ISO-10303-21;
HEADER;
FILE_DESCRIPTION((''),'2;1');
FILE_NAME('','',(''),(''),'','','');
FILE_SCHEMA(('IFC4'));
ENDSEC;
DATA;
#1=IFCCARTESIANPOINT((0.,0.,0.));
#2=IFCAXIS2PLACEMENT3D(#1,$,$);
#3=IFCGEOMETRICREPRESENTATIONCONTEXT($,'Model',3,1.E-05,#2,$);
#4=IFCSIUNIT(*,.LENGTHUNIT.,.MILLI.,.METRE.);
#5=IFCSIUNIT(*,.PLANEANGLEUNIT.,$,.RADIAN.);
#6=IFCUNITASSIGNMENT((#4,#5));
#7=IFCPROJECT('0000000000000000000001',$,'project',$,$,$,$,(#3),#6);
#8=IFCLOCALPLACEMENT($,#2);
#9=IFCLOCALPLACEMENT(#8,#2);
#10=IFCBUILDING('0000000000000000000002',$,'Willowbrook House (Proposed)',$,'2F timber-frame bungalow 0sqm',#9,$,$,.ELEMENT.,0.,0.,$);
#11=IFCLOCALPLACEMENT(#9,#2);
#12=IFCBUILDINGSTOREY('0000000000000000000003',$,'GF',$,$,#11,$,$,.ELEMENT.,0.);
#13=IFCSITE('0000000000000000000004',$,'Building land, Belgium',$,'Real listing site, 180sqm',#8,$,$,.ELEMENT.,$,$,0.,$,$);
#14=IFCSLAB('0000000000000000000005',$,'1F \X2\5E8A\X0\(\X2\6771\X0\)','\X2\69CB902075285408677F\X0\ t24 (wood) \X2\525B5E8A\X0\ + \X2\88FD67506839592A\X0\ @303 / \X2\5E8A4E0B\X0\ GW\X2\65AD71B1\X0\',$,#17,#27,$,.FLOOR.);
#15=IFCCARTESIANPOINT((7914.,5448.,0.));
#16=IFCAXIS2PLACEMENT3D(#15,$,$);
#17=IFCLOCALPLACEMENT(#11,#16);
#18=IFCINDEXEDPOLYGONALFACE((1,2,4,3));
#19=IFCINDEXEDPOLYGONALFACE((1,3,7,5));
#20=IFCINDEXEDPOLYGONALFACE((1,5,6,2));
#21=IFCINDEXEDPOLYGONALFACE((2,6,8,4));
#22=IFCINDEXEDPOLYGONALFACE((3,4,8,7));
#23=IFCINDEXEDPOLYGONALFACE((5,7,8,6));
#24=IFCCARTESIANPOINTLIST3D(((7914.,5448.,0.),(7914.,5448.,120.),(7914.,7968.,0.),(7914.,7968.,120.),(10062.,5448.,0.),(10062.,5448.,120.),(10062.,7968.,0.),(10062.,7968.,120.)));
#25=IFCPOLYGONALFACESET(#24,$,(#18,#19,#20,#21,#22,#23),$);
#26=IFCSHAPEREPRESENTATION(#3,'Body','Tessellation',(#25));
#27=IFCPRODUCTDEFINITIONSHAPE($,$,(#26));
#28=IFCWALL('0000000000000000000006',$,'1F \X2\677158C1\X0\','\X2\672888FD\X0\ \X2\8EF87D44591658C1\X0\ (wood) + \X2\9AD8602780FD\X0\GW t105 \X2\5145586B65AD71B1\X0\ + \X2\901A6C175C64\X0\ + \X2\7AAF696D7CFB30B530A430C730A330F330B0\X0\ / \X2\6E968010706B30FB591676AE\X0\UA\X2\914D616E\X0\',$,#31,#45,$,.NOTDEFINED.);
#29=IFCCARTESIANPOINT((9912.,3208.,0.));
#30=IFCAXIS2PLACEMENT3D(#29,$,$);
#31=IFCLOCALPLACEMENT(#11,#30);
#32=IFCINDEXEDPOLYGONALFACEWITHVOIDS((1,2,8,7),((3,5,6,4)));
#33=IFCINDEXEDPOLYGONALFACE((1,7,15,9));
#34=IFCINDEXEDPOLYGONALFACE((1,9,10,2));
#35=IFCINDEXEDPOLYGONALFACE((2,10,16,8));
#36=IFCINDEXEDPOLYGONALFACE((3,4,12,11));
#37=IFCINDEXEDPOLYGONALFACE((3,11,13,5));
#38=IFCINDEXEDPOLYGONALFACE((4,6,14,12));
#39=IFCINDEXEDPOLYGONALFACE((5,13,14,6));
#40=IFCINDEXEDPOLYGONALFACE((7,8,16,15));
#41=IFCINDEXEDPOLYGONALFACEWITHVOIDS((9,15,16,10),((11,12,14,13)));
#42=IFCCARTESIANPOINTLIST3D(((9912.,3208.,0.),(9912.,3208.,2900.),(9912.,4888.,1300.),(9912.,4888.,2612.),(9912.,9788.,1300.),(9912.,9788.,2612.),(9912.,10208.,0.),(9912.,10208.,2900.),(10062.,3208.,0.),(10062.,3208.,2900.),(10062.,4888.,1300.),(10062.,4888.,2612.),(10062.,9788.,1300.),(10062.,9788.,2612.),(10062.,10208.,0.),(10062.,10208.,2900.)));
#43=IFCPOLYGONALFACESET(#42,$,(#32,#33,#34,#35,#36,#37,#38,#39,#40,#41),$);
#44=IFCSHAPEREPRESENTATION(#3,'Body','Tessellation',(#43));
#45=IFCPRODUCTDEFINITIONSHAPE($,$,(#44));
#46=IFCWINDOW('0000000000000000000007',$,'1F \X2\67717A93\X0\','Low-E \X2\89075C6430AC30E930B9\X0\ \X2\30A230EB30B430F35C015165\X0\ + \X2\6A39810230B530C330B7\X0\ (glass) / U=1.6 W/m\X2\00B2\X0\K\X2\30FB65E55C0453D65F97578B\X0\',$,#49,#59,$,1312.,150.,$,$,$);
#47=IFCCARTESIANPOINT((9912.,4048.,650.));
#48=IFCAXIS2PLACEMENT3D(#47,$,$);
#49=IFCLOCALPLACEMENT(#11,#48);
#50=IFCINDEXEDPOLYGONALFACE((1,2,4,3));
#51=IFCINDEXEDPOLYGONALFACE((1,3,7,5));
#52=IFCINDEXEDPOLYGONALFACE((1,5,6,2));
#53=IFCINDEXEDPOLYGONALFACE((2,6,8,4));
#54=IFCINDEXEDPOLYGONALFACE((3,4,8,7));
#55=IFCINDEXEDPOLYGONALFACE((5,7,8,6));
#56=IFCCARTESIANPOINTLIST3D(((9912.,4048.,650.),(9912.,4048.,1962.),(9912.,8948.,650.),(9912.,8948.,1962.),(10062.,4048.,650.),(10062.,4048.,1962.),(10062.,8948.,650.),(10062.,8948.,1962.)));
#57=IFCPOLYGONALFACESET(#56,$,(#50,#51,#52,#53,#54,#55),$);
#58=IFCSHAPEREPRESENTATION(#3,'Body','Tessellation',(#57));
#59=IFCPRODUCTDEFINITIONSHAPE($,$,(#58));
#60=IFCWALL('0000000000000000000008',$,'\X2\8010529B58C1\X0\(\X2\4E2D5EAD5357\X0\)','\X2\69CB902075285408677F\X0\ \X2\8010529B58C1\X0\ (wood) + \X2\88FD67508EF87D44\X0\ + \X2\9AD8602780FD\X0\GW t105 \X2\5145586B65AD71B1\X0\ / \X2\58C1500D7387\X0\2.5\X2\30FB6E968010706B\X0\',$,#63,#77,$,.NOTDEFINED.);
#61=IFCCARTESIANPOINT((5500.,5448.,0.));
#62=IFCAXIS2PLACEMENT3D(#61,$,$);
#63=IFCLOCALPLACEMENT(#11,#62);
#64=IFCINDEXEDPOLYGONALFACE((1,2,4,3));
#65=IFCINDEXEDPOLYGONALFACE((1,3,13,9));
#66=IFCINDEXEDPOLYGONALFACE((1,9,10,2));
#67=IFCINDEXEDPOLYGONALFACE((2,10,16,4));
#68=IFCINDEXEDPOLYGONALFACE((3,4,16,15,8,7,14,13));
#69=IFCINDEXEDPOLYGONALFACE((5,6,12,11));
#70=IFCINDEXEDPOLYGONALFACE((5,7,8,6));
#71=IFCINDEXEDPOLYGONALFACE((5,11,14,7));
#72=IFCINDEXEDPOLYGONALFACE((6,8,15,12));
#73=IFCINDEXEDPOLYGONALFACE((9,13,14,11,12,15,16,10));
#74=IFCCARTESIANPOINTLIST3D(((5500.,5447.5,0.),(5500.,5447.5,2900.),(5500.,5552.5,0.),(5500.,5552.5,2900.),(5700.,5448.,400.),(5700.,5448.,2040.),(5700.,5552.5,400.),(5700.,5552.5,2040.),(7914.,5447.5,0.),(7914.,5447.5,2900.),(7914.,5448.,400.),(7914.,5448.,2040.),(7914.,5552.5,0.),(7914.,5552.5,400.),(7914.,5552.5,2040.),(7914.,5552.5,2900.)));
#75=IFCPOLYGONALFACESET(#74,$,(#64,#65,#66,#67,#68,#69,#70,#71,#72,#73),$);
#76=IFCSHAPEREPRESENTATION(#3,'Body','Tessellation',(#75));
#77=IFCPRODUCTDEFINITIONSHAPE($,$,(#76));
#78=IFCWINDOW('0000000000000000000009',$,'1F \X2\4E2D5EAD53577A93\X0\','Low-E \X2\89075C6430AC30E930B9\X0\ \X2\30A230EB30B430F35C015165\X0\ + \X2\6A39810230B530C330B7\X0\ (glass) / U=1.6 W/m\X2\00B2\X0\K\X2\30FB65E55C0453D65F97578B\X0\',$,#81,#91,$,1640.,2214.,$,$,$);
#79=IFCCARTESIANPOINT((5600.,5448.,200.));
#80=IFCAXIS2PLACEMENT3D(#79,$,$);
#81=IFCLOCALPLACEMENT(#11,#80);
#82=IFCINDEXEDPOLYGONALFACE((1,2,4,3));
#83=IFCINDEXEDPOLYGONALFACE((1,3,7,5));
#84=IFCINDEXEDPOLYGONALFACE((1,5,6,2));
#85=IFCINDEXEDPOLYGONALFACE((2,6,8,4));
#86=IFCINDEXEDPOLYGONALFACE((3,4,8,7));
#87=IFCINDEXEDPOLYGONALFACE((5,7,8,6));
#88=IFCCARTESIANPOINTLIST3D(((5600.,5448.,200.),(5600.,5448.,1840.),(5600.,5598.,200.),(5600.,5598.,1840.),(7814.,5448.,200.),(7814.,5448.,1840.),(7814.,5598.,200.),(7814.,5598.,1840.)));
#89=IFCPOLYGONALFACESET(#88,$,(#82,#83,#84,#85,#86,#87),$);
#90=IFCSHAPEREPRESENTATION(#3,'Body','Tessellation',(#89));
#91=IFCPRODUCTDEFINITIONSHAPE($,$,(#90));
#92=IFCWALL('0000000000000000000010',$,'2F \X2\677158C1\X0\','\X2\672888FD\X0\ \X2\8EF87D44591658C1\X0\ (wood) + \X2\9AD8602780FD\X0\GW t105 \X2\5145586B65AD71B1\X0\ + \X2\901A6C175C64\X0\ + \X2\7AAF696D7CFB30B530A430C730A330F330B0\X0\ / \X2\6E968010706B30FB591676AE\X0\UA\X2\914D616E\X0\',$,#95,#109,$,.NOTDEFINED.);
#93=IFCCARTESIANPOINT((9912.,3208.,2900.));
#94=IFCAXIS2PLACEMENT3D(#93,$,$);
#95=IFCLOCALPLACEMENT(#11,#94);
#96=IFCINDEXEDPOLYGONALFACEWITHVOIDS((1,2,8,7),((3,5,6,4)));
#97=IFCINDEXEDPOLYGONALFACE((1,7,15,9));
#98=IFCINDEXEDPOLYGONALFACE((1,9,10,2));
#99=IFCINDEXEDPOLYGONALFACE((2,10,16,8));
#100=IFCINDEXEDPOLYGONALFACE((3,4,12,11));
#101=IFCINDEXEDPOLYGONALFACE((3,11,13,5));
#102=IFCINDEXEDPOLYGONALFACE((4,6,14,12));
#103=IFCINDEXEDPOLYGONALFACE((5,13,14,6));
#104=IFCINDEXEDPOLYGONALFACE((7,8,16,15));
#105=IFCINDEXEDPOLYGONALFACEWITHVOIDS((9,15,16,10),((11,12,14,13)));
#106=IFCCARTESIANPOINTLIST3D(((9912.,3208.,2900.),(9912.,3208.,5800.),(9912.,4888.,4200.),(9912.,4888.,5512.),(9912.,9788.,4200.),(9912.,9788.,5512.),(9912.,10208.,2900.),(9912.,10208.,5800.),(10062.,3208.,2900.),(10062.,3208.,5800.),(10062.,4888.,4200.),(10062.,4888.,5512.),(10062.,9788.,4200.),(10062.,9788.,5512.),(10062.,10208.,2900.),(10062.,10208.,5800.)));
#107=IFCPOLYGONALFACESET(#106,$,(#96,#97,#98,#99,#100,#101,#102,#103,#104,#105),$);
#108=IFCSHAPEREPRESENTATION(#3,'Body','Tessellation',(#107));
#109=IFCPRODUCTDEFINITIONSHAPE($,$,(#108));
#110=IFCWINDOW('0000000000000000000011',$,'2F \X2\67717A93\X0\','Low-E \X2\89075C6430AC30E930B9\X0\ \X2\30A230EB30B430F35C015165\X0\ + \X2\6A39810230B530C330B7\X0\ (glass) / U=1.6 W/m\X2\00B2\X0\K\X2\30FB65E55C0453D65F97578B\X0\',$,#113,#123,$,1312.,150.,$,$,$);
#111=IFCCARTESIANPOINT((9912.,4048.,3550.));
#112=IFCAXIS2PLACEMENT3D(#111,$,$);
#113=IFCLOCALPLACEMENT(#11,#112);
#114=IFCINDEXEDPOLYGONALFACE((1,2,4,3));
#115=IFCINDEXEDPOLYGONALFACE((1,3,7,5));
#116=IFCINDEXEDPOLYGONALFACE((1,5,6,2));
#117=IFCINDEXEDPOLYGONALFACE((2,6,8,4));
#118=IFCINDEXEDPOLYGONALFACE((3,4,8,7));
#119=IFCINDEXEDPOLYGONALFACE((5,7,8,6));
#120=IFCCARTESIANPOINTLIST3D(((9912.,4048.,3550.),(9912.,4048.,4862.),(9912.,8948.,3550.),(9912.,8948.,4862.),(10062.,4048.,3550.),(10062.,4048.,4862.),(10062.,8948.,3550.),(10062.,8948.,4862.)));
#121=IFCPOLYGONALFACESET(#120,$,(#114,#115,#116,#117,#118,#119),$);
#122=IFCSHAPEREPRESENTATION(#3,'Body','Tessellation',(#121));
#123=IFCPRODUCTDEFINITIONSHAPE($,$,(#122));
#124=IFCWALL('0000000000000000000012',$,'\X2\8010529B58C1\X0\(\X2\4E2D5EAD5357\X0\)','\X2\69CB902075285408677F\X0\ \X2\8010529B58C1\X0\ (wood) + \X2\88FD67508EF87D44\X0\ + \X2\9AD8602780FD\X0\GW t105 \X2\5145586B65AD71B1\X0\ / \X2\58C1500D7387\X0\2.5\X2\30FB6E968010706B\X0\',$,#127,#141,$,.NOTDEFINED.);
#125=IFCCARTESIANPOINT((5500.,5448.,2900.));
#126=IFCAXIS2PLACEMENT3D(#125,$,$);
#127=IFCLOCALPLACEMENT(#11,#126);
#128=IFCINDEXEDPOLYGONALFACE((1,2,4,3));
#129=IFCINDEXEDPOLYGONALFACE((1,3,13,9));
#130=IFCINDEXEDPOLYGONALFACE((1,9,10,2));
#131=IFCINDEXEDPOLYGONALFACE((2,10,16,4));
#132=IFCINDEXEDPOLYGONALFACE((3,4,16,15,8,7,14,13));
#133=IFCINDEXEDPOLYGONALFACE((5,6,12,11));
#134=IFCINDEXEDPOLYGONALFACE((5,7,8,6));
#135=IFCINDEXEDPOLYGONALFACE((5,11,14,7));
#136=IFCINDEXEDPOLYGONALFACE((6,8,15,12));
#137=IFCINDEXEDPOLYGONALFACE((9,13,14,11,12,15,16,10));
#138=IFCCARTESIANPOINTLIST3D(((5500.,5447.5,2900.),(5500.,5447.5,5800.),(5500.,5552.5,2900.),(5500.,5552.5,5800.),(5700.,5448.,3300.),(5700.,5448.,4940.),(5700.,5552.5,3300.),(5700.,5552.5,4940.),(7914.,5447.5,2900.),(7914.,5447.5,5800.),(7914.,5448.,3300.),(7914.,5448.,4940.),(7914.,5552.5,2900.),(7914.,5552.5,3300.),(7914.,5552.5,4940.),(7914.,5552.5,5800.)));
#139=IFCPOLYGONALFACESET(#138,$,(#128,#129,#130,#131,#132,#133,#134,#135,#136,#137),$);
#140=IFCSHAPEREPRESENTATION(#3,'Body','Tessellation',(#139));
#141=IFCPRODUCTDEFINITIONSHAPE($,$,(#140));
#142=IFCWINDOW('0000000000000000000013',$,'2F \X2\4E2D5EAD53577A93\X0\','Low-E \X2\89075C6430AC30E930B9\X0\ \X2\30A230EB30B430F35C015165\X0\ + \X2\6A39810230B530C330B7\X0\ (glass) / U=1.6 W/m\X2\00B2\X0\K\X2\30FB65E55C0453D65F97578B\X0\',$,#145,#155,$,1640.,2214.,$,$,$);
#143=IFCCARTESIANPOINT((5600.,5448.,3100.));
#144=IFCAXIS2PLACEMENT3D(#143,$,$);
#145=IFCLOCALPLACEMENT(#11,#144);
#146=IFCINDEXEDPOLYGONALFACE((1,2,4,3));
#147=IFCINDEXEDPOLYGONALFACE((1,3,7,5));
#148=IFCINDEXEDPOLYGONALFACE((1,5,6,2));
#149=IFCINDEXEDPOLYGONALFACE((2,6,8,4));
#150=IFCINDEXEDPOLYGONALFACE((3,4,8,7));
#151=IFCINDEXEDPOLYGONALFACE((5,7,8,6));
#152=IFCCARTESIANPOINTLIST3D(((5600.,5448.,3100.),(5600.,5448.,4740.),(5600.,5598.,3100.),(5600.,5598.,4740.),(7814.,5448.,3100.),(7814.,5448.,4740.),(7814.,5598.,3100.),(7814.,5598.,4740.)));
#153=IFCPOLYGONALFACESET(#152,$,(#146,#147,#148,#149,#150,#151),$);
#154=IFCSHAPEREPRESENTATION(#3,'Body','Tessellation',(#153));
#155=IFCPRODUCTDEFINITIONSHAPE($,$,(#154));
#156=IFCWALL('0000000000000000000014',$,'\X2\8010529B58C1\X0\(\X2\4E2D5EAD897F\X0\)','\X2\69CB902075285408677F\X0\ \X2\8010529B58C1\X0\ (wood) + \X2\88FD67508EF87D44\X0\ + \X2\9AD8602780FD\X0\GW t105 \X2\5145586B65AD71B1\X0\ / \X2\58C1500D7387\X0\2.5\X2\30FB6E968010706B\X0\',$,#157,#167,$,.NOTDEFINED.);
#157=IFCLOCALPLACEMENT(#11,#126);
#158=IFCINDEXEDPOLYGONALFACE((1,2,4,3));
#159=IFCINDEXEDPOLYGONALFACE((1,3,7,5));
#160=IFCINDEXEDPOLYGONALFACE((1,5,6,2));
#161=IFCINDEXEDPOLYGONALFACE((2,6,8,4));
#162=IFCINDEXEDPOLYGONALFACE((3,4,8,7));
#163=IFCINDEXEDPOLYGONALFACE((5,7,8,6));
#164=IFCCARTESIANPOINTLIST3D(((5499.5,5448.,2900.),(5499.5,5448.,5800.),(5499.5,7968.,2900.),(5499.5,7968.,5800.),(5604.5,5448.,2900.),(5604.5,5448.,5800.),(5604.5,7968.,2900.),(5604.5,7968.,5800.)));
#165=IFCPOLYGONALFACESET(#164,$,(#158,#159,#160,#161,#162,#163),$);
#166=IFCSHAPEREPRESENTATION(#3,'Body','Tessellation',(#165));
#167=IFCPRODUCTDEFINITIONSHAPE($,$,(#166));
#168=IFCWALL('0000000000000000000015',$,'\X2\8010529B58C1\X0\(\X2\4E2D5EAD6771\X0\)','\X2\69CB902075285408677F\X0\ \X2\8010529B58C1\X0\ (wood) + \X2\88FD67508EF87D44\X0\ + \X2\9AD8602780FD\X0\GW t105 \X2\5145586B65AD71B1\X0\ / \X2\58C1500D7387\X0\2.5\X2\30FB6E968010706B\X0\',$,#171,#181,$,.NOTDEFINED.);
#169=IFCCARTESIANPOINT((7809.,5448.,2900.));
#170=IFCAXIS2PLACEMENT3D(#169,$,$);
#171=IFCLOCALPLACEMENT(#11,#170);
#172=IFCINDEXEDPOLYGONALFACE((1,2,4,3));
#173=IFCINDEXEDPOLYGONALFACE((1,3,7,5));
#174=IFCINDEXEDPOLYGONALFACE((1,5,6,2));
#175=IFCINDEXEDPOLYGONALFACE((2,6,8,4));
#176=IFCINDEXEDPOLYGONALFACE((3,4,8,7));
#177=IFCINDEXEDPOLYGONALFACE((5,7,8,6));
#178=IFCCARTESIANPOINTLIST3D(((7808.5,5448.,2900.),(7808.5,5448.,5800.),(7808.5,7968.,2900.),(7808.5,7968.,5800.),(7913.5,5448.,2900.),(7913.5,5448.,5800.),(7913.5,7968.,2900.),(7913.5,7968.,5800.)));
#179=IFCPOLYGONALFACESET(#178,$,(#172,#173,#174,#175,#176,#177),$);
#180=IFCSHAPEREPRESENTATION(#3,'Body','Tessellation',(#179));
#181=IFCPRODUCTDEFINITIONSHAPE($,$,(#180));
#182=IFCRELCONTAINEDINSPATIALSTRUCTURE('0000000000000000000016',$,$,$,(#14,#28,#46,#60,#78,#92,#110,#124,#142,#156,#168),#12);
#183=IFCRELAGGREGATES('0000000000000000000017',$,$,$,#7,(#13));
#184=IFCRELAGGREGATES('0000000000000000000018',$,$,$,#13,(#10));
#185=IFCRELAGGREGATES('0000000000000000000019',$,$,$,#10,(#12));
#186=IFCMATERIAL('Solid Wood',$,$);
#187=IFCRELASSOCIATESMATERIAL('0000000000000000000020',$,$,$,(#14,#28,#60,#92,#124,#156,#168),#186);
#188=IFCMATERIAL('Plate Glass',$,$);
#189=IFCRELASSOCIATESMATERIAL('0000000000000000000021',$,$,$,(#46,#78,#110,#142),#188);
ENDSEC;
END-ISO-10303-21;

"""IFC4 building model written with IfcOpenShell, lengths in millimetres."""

from ifc_helpers import new_model, si_unit, frame, frame_2d, origin, place, context, project, spatial, rectangle, extrude, material, element, fill, save


model = new_model("IFC4")

# Units and contexts
model_context = context("Model", 3, precision=1e-05, world=origin())
ifc_project = project(units=[si_unit("LENGTHUNIT", "METRE", prefix="MILLI"), si_unit("PLANEANGLEUNIT", "RADIAN")], contexts=[model_context])

# Site, building, storey
site_placement = place(None, origin())
site = spatial("IfcSite", under=ifc_project, at=site_placement, Name="Building land, Belgium", ObjectType="Real listing site, 180sqm", CompositionType="ELEMENT", RefElevation=0.0)
building_placement = place(site_placement, origin())
building = spatial("IfcBuilding", under=site, at=building_placement, Name="Willowbrook House (Proposed)", ObjectType="2F timber-frame bungalow 0sqm", CompositionType="ELEMENT", ElevationOfRefHeight=0.0, ElevationOfTerrain=0.0)
storey_placement = place(building_placement, origin())
storey = spatial("IfcBuildingStorey", under=building, at=storey_placement, Name="GF", CompositionType="ELEMENT", Elevation=0.0)

# Slab
ifc_material_1 = material(Name="Solid Wood")
slab_placement = place(storey_placement, frame((7914.0, 5448.0, 0.0)))
element("IfcSlab", 1, at=slab_placement, inside=storey, material=ifc_material_1, Name="1F 床(東)", Description="構造用合板 t24 (wood) 剛床 + 製材根太 @303 / 床下 GW断熱", PredefinedType="FLOOR", context=model_context, shape_type="SweptSolid", body=[
    extrude(rectangle(XDim=2148.0, YDim=2520.0, at=frame_2d((1074.0, 1260.0))), frame((7914.0, 5448.0, 0.0)), (0.0, 0.0, 1.0), 120.0),
])

# Walls, openings, windows
wall_1_placement = place(storey_placement, frame((9912.0, 3208.0, 0.0)))
wall_1 = element("IfcWall", 2, at=wall_1_placement, inside=storey, material=ifc_material_1, Name="1F 東壁", Description="木製 軸組外壁 (wood) + 高性能GW t105 充填断熱 + 通気層 + 窯業系サイディング / 準耐火・外皮UA配慮", PredefinedType="NOTDEFINED", context=model_context, shape_type="SweptSolid", body=[
    extrude(rectangle(XDim=150.0, YDim=7000.0, at=frame_2d((75.0, 3500.0))), frame((9912.0, 3208.0, 0.0)), (0.0, 0.0, 1.0), 2900.0),
])
opening_1_placement = place(storey_placement, frame((9912.0, 4048.0, 650.0)))
opening_1 = element("IfcOpeningElement", 3, at=opening_1_placement, cuts=wall_1, PredefinedType="NOTDEFINED", context=model_context, shape_type="SweptSolid", body=[
    extrude(rectangle(XDim=150.0, YDim=4900.0, at=frame_2d((75.0, 2450.0))), frame((9912.0, 4048.0, 650.0)), (0.0, 0.0, 1.0), 1312.0),
])
ifc_material_2 = material(Name="Plate Glass")
window_1_placement = place(storey_placement, frame((9912.0, 4048.0, 650.0)))
window_1 = element("IfcWindow", 4, at=window_1_placement, inside=storey, material=ifc_material_2, Name="1F 東窓", Description="Low-E 複層ガラス アルゴン封入 + 樹脂サッシ (glass) / U=1.6 W/m²K・日射取得型", OverallHeight=1312.0, OverallWidth=150.0, context=model_context, shape_type="SweptSolid", body=[
    extrude(rectangle(XDim=150.0, YDim=4900.0, at=frame_2d((75.0, 2450.0))), frame((9912.0, 4048.0, 650.0)), (0.0, 0.0, 1.0), 1312.0),
])
fill(opening_1, window_1)
wall_2_placement = place(storey_placement, frame((5500.0, 5448.0, 0.0)))
wall_2 = element("IfcWall", 5, at=wall_2_placement, inside=storey, material=ifc_material_1, Name="耐力壁(中庭南)", Description="構造用合板 耐力壁 (wood) + 製材軸組 + 高性能GW t105 充填断熱 / 壁倍率2.5・準耐火", PredefinedType="NOTDEFINED", context=model_context, shape_type="SweptSolid", body=[
    extrude(rectangle(XDim=2414.0, YDim=105.0, at=frame_2d((1207.0, 52.0))), frame((5500.0, 5448.0, 0.0)), (0.0, 0.0, 1.0), 2900.0),
])
opening_2_placement = place(storey_placement, frame((5600.0, 5448.0, 200.0)))
opening_2 = element("IfcOpeningElement", 6, at=opening_2_placement, cuts=wall_2, PredefinedType="NOTDEFINED", context=model_context, shape_type="SweptSolid", body=[
    extrude(rectangle(XDim=2214.0, YDim=150.0, at=frame_2d((1107.0, 75.0))), frame((5600.0, 5448.0, 200.0)), (0.0, 0.0, 1.0), 1640.0),
])
window_2_placement = place(storey_placement, frame((5600.0, 5448.0, 200.0)))
window_2 = element("IfcWindow", 7, at=window_2_placement, inside=storey, material=ifc_material_2, Name="1F 中庭南窓", Description="Low-E 複層ガラス アルゴン封入 + 樹脂サッシ (glass) / U=1.6 W/m²K・日射取得型", OverallHeight=1640.0, OverallWidth=2214.0, context=model_context, shape_type="SweptSolid", body=[
    extrude(rectangle(XDim=2214.0, YDim=150.0, at=frame_2d((1107.0, 75.0))), frame((5600.0, 5448.0, 200.0)), (0.0, 0.0, 1.0), 1640.0),
])
fill(opening_2, window_2)

# Walls, openings, windows
wall_3_placement = place(storey_placement, frame((9912.0, 3208.0, 2900.0)))
wall_3 = element("IfcWall", 8, at=wall_3_placement, inside=storey, material=ifc_material_1, Name="2F 東壁", Description="木製 軸組外壁 (wood) + 高性能GW t105 充填断熱 + 通気層 + 窯業系サイディング / 準耐火・外皮UA配慮", PredefinedType="NOTDEFINED", context=model_context, shape_type="SweptSolid", body=[
    extrude(rectangle(XDim=150.0, YDim=7000.0, at=frame_2d((75.0, 3500.0))), frame((9912.0, 3208.0, 2900.0)), (0.0, 0.0, 1.0), 2900.0),
])
opening_3_placement = place(storey_placement, frame((9912.0, 4048.0, 3550.0)))
opening_3 = element("IfcOpeningElement", 9, at=opening_3_placement, cuts=wall_3, PredefinedType="NOTDEFINED", context=model_context, shape_type="SweptSolid", body=[
    extrude(rectangle(XDim=150.0, YDim=4900.0, at=frame_2d((75.0, 2450.0))), frame((9912.0, 4048.0, 3550.0)), (0.0, 0.0, 1.0), 1312.0),
])
window_3_placement = place(storey_placement, frame((9912.0, 4048.0, 3550.0)))
window_3 = element("IfcWindow", 10, at=window_3_placement, inside=storey, material=ifc_material_2, Name="2F 東窓", Description="Low-E 複層ガラス アルゴン封入 + 樹脂サッシ (glass) / U=1.6 W/m²K・日射取得型", OverallHeight=1312.0, OverallWidth=150.0, context=model_context, shape_type="SweptSolid", body=[
    extrude(rectangle(XDim=150.0, YDim=4900.0, at=frame_2d((75.0, 2450.0))), frame((9912.0, 4048.0, 3550.0)), (0.0, 0.0, 1.0), 1312.0),
])
fill(opening_3, window_3)
wall_4_placement = place(storey_placement, frame((5500.0, 5448.0, 2900.0)))
wall_4 = element("IfcWall", 11, at=wall_4_placement, inside=storey, material=ifc_material_1, Name="耐力壁(中庭南)", Description="構造用合板 耐力壁 (wood) + 製材軸組 + 高性能GW t105 充填断熱 / 壁倍率2.5・準耐火", PredefinedType="NOTDEFINED", context=model_context, shape_type="SweptSolid", body=[
    extrude(rectangle(XDim=2414.0, YDim=105.0, at=frame_2d((1207.0, 52.0))), frame((5500.0, 5448.0, 2900.0)), (0.0, 0.0, 1.0), 2900.0),
])
opening_4_placement = place(storey_placement, frame((5600.0, 5448.0, 3100.0)))
opening_4 = element("IfcOpeningElement", 12, at=opening_4_placement, cuts=wall_4, PredefinedType="NOTDEFINED", context=model_context, shape_type="SweptSolid", body=[
    extrude(rectangle(XDim=2214.0, YDim=150.0, at=frame_2d((1107.0, 75.0))), frame((5600.0, 5448.0, 3100.0)), (0.0, 0.0, 1.0), 1640.0),
])
window_4_placement = place(storey_placement, frame((5600.0, 5448.0, 3100.0)))
window_4 = element("IfcWindow", 13, at=window_4_placement, inside=storey, material=ifc_material_2, Name="2F 中庭南窓", Description="Low-E 複層ガラス アルゴン封入 + 樹脂サッシ (glass) / U=1.6 W/m²K・日射取得型", OverallHeight=1640.0, OverallWidth=2214.0, context=model_context, shape_type="SweptSolid", body=[
    extrude(rectangle(XDim=2214.0, YDim=150.0, at=frame_2d((1107.0, 75.0))), frame((5600.0, 5448.0, 3100.0)), (0.0, 0.0, 1.0), 1640.0),
])
fill(opening_4, window_4)

# Walls
wall_5_placement = place(storey_placement, frame((5500.0, 5448.0, 2900.0)))
element("IfcWall", 14, at=wall_5_placement, inside=storey, material=ifc_material_1, Name="耐力壁(中庭西)", Description="構造用合板 耐力壁 (wood) + 製材軸組 + 高性能GW t105 充填断熱 / 壁倍率2.5・準耐火", PredefinedType="NOTDEFINED", context=model_context, shape_type="SweptSolid", body=[
    extrude(rectangle(XDim=105.0, YDim=2520.0, at=frame_2d((52.0, 1260.0))), frame((5500.0, 5448.0, 2900.0)), (0.0, 0.0, 1.0), 2900.0),
])
wall_6_placement = place(storey_placement, frame((7809.0, 5448.0, 2900.0)))
element("IfcWall", 15, at=wall_6_placement, inside=storey, material=ifc_material_1, Name="耐力壁(中庭東)", Description="構造用合板 耐力壁 (wood) + 製材軸組 + 高性能GW t105 充填断熱 / 壁倍率2.5・準耐火", PredefinedType="NOTDEFINED", context=model_context, shape_type="SweptSolid", body=[
    extrude(rectangle(XDim=105.0, YDim=2520.0, at=frame_2d((52.0, 1260.0))), frame((7809.0, 5448.0, 2900.0)), (0.0, 0.0, 1.0), 2900.0),
])

save(model, "model.ifc")
